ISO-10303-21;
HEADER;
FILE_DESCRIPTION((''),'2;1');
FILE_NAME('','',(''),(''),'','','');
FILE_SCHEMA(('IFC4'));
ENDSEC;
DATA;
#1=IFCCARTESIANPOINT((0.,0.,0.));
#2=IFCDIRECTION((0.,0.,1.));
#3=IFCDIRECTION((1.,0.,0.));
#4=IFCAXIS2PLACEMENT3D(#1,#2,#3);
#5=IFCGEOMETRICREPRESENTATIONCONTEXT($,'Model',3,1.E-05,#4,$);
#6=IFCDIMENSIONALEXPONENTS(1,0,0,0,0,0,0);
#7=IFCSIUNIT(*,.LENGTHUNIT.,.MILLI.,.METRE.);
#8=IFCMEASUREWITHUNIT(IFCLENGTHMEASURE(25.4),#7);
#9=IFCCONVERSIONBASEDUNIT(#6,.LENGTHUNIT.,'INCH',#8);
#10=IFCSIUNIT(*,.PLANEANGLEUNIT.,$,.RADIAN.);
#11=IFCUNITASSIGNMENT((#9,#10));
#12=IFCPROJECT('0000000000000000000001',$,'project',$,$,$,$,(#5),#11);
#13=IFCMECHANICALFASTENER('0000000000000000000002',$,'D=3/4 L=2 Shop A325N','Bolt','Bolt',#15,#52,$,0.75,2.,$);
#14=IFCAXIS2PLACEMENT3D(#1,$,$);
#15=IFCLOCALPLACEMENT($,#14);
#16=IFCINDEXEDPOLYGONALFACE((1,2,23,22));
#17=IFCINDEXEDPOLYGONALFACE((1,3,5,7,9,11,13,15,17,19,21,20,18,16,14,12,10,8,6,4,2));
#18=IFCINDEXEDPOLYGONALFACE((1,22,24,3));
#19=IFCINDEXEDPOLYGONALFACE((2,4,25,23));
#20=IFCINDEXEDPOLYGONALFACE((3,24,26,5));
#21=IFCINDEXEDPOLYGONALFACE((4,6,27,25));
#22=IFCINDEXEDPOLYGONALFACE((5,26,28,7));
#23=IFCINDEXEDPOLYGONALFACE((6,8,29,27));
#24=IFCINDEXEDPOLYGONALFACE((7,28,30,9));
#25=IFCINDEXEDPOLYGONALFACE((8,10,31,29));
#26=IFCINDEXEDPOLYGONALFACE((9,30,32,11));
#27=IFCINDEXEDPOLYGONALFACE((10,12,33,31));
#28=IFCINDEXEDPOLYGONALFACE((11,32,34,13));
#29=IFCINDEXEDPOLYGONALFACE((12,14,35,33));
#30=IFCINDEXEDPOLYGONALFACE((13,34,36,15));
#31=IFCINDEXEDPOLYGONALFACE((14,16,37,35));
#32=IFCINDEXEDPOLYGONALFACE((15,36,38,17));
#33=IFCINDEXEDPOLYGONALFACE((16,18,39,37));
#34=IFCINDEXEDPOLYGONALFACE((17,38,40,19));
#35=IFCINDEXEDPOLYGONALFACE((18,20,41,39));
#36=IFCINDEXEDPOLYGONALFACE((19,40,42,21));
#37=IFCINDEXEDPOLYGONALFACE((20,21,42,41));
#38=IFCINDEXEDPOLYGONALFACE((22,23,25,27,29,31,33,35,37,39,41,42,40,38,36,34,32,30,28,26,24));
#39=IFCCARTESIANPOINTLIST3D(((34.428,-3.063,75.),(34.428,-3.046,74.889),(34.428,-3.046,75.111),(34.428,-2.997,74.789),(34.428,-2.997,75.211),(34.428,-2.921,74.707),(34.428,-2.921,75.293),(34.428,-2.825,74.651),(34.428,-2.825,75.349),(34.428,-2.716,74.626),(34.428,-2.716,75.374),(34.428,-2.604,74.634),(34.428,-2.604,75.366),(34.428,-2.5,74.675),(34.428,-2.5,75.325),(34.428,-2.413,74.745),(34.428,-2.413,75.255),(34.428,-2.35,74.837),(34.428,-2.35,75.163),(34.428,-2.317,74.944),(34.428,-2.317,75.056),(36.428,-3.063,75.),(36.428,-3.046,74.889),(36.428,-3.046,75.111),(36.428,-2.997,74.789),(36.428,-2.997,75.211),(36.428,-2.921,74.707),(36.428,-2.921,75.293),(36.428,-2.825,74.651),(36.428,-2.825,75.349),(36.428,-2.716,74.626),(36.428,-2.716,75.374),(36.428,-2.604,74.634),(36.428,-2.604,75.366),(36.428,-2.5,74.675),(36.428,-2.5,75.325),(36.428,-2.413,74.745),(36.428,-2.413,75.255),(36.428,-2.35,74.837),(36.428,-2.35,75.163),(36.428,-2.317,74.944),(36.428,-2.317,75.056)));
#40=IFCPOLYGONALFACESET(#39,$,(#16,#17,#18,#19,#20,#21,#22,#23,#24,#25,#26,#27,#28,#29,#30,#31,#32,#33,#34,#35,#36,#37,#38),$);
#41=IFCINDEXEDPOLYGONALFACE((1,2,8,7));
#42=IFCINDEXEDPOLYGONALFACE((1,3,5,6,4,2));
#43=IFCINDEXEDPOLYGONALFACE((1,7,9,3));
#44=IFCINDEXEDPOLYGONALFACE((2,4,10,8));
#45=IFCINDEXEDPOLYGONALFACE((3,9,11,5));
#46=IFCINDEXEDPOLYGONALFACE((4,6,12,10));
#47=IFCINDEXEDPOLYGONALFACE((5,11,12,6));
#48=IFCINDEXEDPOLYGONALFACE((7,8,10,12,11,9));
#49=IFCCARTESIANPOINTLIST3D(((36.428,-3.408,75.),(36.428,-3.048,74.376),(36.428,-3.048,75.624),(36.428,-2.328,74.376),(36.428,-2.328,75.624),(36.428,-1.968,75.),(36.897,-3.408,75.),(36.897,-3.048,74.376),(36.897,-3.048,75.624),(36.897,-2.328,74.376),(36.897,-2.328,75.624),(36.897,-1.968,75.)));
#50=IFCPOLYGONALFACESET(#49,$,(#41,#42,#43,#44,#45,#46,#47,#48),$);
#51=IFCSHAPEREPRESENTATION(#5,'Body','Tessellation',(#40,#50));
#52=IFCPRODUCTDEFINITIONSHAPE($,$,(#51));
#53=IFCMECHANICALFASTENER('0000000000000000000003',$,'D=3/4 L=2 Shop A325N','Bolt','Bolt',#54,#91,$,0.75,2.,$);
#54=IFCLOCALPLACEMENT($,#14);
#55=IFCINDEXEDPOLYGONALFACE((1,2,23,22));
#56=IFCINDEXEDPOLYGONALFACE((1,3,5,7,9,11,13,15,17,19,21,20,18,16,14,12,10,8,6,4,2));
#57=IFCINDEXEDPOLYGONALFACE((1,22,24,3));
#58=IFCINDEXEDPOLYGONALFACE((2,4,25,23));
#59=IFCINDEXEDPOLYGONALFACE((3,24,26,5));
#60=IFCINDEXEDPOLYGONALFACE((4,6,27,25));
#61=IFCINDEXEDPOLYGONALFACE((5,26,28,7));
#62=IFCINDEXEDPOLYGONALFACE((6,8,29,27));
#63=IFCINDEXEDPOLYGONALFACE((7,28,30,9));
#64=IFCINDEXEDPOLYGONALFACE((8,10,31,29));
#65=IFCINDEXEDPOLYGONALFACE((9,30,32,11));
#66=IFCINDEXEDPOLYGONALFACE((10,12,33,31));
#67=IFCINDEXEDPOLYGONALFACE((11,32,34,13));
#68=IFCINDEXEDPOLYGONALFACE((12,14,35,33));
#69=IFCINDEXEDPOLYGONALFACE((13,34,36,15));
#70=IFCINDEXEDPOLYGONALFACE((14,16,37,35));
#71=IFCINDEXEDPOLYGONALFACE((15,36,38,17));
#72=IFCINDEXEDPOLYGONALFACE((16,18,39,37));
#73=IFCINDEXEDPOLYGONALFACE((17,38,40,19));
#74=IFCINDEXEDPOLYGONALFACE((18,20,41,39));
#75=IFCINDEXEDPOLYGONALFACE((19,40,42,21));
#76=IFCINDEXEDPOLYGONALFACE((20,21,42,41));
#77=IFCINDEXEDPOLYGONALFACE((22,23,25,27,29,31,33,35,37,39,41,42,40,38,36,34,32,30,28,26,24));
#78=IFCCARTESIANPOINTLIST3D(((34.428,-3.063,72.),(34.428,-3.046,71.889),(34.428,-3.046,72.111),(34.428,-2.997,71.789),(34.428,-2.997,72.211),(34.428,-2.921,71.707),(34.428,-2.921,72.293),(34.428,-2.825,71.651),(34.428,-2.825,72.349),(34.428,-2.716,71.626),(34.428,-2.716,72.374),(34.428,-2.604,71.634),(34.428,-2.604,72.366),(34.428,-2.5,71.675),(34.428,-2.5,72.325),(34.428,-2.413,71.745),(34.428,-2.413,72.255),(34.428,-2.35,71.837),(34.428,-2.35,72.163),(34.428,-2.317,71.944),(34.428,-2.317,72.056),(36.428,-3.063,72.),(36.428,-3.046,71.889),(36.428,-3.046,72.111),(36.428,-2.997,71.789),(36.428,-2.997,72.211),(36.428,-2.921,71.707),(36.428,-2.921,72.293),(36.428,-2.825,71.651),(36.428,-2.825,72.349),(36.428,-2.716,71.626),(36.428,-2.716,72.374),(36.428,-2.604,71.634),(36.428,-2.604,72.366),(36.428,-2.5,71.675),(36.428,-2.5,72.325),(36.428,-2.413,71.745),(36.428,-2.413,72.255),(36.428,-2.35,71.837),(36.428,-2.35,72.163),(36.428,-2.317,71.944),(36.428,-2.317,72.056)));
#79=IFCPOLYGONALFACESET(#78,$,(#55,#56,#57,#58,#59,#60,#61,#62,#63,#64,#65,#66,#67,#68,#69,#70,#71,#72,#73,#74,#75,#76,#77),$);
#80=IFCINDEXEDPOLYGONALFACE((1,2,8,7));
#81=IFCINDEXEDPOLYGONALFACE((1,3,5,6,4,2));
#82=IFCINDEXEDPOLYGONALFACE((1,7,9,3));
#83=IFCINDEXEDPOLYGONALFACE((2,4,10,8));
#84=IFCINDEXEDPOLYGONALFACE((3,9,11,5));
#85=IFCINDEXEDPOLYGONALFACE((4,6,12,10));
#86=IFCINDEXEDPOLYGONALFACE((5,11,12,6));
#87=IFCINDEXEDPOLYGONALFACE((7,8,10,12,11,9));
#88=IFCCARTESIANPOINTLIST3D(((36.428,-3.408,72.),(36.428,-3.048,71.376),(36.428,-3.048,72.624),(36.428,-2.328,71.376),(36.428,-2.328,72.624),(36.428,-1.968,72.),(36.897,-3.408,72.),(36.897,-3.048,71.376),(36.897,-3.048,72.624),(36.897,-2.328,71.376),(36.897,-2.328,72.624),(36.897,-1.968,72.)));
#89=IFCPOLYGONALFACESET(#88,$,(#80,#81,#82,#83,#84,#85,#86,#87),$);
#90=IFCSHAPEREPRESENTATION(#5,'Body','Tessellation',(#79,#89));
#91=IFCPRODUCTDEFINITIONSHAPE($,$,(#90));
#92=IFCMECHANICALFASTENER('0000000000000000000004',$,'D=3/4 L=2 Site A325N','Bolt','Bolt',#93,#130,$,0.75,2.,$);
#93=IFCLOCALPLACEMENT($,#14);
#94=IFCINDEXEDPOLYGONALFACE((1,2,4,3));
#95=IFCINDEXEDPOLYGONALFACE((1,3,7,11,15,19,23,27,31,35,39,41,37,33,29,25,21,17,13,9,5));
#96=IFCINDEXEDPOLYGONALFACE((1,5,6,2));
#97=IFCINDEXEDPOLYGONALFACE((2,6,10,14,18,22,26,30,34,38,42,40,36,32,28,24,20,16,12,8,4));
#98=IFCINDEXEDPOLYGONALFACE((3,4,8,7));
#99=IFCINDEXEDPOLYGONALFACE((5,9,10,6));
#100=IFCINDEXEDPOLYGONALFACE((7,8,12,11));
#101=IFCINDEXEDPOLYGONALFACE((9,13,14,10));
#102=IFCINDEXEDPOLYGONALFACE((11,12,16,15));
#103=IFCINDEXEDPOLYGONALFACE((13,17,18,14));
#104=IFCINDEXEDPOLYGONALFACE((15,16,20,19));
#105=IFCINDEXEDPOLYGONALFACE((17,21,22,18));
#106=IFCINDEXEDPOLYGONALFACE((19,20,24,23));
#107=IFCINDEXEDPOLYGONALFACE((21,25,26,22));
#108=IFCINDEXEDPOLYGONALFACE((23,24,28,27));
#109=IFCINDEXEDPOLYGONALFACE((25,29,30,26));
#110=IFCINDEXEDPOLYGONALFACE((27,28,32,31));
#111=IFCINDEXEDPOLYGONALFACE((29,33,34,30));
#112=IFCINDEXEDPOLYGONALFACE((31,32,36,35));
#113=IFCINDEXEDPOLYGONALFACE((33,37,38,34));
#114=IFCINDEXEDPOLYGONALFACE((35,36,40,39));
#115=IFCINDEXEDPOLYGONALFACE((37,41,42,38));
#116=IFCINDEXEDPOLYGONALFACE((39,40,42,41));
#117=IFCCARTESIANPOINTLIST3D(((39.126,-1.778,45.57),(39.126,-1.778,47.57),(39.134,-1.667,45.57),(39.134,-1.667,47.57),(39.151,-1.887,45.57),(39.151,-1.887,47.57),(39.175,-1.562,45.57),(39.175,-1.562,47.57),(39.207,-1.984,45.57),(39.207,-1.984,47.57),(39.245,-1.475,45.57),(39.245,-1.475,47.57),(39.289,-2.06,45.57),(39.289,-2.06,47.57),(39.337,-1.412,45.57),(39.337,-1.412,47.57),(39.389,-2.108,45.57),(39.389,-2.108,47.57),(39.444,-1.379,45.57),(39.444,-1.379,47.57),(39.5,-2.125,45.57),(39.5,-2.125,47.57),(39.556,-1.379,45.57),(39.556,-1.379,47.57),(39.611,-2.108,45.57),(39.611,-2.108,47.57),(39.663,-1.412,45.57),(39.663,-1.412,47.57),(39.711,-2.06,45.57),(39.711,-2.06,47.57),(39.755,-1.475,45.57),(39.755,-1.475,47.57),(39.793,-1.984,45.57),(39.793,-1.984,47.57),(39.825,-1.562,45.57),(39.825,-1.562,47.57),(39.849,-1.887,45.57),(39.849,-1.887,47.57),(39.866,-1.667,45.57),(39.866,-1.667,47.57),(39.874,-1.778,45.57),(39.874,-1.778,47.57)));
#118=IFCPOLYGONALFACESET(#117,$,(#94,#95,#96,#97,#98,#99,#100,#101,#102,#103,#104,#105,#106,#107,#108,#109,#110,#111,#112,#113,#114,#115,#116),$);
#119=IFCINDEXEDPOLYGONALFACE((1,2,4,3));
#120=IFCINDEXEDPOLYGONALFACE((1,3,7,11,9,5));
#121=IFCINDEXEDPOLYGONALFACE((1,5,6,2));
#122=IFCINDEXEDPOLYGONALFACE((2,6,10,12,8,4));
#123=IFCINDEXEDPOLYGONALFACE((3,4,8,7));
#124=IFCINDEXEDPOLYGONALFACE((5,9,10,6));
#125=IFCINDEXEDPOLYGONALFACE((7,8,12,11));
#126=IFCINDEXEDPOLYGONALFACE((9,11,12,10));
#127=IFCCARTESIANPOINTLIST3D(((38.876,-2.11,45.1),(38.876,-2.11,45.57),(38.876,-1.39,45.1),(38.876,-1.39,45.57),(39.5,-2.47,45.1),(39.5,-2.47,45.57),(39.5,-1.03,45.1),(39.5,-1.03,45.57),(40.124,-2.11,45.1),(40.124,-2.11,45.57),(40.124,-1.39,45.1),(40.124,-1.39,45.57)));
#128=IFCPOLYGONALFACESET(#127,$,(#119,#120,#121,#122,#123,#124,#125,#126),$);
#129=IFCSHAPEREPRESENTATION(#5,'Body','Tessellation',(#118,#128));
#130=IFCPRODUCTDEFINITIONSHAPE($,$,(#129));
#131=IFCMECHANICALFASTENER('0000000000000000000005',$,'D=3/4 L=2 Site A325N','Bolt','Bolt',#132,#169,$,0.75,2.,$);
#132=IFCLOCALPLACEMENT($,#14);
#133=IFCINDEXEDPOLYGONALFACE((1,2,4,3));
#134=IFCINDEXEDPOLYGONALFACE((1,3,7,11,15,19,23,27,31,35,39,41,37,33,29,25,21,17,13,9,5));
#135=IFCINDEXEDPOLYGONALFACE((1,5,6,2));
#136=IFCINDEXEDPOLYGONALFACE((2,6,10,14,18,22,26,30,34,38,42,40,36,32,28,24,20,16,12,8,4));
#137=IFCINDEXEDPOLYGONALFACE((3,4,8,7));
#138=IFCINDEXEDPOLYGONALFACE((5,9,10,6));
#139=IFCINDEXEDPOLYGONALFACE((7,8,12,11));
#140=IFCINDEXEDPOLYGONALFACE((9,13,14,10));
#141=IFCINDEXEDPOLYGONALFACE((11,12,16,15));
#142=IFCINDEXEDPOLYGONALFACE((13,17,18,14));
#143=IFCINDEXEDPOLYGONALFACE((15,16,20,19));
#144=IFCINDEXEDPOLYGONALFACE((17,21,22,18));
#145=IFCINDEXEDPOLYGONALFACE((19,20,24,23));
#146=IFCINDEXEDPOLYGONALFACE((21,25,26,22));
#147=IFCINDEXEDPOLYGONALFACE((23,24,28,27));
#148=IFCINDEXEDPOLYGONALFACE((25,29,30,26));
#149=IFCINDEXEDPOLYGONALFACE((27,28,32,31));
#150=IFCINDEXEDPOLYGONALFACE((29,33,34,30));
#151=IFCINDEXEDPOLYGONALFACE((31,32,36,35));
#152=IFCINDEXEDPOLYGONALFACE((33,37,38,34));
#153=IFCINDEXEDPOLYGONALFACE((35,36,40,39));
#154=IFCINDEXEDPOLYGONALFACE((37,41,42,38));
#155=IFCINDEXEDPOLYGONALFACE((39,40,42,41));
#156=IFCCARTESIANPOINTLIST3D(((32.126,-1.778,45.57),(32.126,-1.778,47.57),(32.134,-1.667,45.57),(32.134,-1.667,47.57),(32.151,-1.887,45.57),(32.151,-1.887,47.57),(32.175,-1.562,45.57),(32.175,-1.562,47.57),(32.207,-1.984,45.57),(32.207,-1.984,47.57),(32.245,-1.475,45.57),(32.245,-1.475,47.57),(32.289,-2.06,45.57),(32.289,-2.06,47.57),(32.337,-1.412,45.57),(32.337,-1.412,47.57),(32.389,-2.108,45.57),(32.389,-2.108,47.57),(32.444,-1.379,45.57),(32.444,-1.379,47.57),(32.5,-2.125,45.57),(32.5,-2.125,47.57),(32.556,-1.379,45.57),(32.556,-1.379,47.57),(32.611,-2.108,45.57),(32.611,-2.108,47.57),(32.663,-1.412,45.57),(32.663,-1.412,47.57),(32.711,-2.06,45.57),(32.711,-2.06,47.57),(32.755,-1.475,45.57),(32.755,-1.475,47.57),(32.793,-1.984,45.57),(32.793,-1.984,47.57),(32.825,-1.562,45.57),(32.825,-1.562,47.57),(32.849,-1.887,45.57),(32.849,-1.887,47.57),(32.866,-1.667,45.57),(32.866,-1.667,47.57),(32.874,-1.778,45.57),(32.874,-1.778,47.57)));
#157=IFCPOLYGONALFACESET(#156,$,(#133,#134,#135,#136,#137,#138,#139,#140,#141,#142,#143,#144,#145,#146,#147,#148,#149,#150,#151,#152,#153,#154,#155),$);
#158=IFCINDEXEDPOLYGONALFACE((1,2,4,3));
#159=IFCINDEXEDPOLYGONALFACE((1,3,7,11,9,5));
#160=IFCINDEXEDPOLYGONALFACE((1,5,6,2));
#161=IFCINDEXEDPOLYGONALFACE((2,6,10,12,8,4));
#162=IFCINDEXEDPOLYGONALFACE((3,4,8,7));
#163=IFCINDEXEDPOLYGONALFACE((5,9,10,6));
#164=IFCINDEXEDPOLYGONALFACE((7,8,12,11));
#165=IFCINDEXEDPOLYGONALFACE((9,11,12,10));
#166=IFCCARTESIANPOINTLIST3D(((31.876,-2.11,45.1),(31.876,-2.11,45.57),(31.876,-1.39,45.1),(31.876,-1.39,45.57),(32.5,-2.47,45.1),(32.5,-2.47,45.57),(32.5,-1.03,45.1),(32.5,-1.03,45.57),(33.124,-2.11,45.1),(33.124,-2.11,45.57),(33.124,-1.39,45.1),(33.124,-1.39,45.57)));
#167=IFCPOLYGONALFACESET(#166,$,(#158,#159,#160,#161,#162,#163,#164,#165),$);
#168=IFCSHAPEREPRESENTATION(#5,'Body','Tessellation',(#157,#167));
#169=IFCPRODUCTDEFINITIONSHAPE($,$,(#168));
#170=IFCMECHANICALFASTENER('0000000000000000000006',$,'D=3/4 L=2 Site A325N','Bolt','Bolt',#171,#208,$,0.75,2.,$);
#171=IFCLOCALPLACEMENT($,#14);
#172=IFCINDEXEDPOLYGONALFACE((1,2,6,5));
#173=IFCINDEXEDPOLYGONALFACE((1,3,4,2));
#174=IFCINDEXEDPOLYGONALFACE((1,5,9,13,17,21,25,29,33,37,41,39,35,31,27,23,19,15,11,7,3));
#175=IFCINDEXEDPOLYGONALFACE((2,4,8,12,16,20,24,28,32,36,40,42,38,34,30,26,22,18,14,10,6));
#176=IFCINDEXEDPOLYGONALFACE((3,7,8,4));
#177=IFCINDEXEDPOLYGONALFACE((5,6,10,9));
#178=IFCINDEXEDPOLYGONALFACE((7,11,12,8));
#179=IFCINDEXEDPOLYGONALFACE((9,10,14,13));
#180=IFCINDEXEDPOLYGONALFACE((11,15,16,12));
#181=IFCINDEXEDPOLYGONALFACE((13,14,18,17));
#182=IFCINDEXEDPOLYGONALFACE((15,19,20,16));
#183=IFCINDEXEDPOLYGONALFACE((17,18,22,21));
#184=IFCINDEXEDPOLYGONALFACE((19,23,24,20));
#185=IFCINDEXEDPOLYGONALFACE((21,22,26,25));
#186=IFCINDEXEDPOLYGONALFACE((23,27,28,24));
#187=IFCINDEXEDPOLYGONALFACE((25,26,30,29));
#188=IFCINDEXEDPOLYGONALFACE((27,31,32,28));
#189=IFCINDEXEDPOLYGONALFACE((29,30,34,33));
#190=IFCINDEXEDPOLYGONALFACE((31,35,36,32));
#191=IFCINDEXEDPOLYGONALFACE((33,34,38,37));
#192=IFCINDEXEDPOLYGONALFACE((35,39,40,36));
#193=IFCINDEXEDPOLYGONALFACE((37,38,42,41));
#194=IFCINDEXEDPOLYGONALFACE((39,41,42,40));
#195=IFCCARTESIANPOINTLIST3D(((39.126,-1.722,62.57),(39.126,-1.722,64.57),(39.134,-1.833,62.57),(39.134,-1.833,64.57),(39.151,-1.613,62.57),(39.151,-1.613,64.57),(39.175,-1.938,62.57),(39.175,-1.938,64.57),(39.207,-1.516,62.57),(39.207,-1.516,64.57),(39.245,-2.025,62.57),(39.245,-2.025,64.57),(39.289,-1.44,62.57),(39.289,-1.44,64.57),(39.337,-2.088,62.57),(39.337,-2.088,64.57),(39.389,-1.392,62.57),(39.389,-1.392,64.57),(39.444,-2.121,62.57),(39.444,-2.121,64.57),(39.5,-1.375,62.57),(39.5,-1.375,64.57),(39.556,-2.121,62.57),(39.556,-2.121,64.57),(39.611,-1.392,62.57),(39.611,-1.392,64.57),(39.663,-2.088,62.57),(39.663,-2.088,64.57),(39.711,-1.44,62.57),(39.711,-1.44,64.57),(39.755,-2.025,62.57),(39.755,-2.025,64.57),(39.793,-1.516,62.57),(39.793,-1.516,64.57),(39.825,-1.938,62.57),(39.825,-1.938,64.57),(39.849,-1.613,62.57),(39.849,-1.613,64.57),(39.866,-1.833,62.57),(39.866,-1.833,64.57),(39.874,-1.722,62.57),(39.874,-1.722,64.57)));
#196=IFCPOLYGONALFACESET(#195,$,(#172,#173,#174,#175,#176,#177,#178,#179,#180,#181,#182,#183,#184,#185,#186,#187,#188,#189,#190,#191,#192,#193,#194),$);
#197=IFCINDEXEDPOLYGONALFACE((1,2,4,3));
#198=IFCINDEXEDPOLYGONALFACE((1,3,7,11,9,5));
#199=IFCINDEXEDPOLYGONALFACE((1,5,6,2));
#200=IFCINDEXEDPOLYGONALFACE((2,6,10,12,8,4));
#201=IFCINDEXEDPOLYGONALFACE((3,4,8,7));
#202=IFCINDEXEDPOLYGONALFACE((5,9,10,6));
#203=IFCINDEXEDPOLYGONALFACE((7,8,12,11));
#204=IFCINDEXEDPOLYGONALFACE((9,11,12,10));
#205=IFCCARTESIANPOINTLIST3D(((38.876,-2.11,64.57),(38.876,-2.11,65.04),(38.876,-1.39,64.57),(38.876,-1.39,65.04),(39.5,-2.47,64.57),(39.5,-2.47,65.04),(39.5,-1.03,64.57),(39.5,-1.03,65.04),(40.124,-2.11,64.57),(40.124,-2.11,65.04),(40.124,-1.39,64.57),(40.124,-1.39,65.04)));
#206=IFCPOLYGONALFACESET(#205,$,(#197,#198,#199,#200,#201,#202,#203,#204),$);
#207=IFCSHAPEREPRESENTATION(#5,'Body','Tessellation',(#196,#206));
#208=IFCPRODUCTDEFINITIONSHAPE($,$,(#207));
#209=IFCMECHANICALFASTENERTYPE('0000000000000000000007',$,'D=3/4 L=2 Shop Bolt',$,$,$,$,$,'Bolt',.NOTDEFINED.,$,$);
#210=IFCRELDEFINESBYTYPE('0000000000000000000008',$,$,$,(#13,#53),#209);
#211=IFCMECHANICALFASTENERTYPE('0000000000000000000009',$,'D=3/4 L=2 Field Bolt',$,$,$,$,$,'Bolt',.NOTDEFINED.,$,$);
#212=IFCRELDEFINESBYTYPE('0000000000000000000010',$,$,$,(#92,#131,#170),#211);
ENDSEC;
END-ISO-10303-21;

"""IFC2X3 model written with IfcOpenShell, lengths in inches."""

from ifc_helpers import new_model, entity, si_unit, converted_unit, frame, origin_with_axes, origin_2d_with_axis, place, context, project, polyline, circle, outline, extrude, source, transform, mapped, type_object, type_shapes, element, save


model = new_model("IFC2X3")

# Units and contexts
model_context = context("Model", 3, precision=1e-05, world=origin_with_axes())
ifc_project = project(units=[converted_unit("LENGTHUNIT", "INCH", entity("IfcLengthMeasure", 25.4), si_unit("LENGTHUNIT", "METRE", prefix="MILLI"), dimensions=[1, 0, 0, 0, 0, 0, 0]), si_unit("PLANEANGLEUNIT", "RADIAN")], contexts=[model_context])

# Mechanical fasteners
placement_1 = place(None, origin_with_axes())
placement_2 = place(placement_1, origin_with_axes())
mechanical_fastener_type_1 = type_object("IfcMechanicalFastenerType", Name="D=3/4 L=2 Shop Bolt", ElementType="Bolt")
shared_shape_1 = source(origin_with_axes(), model_context, "Body", "SweptSolid", [
    extrude(circle(Radius=0.375, at=origin_2d_with_axis()), frame((0.0, 0.0, 0.0), z_axis=(1.0, 0.0, 0.0), x_axis=(0.0, 1.0, 0.0)), (0.0, 0.0, 1.0), 2.0),
    extrude(outline(polyline([(-0.72, 0.0), (-0.36, 0.624), (0.36, 0.624), (0.72, 0.0), (0.36, -0.624), (-0.36, -0.624), (-0.72, 0.0)])), frame((0.0, 0.0, 0.0), z_axis=(1.0, 0.0, 0.0), x_axis=(0.0, 1.0, 0.0)), (0.0, 0.0, -1.0), 0.47),
])
type_shapes(mechanical_fastener_type_1, [shared_shape_1])
placement_3 = place(placement_2, frame((36.0, 0.0, 78.0), z_axis=(0.0, 0.0, 1.0), x_axis=(0.0, -1.0, 0.0)))
placement_4 = place(placement_3, frame((2.688, 0.428, -6.0), z_axis=(0.0, 0.0, 1.0), x_axis=(0.0, -1.0, 0.0)))
for number, where, z_axis, x_axis, name in (
    (1, (0.0, 0.0, 3.0), (0.0, 0.0, 1.0), (1.0, 0.0, 0.0), "D=3/4 L=2 Shop A325N"),
    (2, (0.0, 0.0, 0.0), (0.0, 0.0, 1.0), (1.0, 0.0, 0.0), "D=3/4 L=2 Shop A325N"),
):
    element("IfcMechanicalFastener", number, at=place(placement_4, frame(where, z_axis=z_axis, x_axis=x_axis)), type_object=mechanical_fastener_type_1, Name=name, Description="Bolt", ObjectType="Bolt", NominalDiameter=0.75, NominalLength=2.0, context=model_context, shape_type="MappedRepresentation", body=[
        mapped(shared_shape_1, transform((0.0, 0.0, 0.0), scale=1.0)),
    ])
mechanical_fastener_type_2 = type_object("IfcMechanicalFastenerType", Name="D=3/4 L=2 Field Bolt", ElementType="Bolt")
shared_shape_2 = source(origin_with_axes(), model_context, "Body", "SweptSolid", [
    extrude(circle(Radius=0.375, at=origin_2d_with_axis()), frame((0.0, 0.0, 0.0), z_axis=(1.0, 0.0, 0.0), x_axis=(0.0, 1.0, 0.0)), (0.0, 0.0, 1.0), 2.0),
    extrude(outline(polyline([(-0.72, 0.0), (-0.36, 0.624), (0.36, 0.624), (0.72, 0.0), (0.36, -0.624), (-0.36, -0.624), (-0.72, 0.0)])), frame((0.0, 0.0, 0.0), z_axis=(1.0, 0.0, 0.0), x_axis=(0.0, 1.0, 0.0)), (0.0, 0.0, -1.0), 0.47),
])
type_shapes(mechanical_fastener_type_2, [shared_shape_2])
placement_5 = place(placement_2, frame((36.0, 0.0, 46.0), z_axis=(-1.0, 0.0, 0.0), x_axis=(0.0, 0.0, 1.0)))
placement_6 = place(placement_5, frame((-0.43, 1.75, 3.5), z_axis=(0.0, 0.0, -1.0), x_axis=(1.0, 0.0, 0.0)))
for number, where, z_axis, x_axis, name in (
    (3, (0.0, 3.5, 7.0), (0.0, 0.0, 1.0), (1.0, 0.0, 0.0), "D=3/4 L=2 Site A325N"),
    (4, (0.0, 3.5, 0.0), (0.0, 0.0, 1.0), (1.0, 0.0, 0.0), "D=3/4 L=2 Site A325N"),
):
    element("IfcMechanicalFastener", number, at=place(placement_6, frame(where, z_axis=z_axis, x_axis=x_axis)), type_object=mechanical_fastener_type_2, Name=name, Description="Bolt", ObjectType="Bolt", NominalDiameter=0.75, NominalLength=2.0, context=model_context, shape_type="MappedRepresentation", body=[
        mapped(shared_shape_2, transform((0.0, 0.0, 0.0), scale=1.0)),
    ])
placement_7 = place(placement_5, frame((18.57, -1.75, 3.5), z_axis=(0.0, 0.0, -1.0), x_axis=(-1.0, 0.0, 0.0)))
for number, where, z_axis, x_axis, name in (
    (5, (0.0, 0.0, 7.0), (0.0, 0.0, 1.0), (1.0, 0.0, 0.0), "D=3/4 L=2 Site A325N"),
):
    element("IfcMechanicalFastener", number, at=place(placement_7, frame(where, z_axis=z_axis, x_axis=x_axis)), type_object=mechanical_fastener_type_2, Name=name, Description="Bolt", ObjectType="Bolt", NominalDiameter=0.75, NominalLength=2.0, context=model_context, shape_type="MappedRepresentation", body=[
        mapped(shared_shape_2, transform((0.0, 0.0, 0.0), scale=1.0)),
    ])

save(model, "model.ifc")
